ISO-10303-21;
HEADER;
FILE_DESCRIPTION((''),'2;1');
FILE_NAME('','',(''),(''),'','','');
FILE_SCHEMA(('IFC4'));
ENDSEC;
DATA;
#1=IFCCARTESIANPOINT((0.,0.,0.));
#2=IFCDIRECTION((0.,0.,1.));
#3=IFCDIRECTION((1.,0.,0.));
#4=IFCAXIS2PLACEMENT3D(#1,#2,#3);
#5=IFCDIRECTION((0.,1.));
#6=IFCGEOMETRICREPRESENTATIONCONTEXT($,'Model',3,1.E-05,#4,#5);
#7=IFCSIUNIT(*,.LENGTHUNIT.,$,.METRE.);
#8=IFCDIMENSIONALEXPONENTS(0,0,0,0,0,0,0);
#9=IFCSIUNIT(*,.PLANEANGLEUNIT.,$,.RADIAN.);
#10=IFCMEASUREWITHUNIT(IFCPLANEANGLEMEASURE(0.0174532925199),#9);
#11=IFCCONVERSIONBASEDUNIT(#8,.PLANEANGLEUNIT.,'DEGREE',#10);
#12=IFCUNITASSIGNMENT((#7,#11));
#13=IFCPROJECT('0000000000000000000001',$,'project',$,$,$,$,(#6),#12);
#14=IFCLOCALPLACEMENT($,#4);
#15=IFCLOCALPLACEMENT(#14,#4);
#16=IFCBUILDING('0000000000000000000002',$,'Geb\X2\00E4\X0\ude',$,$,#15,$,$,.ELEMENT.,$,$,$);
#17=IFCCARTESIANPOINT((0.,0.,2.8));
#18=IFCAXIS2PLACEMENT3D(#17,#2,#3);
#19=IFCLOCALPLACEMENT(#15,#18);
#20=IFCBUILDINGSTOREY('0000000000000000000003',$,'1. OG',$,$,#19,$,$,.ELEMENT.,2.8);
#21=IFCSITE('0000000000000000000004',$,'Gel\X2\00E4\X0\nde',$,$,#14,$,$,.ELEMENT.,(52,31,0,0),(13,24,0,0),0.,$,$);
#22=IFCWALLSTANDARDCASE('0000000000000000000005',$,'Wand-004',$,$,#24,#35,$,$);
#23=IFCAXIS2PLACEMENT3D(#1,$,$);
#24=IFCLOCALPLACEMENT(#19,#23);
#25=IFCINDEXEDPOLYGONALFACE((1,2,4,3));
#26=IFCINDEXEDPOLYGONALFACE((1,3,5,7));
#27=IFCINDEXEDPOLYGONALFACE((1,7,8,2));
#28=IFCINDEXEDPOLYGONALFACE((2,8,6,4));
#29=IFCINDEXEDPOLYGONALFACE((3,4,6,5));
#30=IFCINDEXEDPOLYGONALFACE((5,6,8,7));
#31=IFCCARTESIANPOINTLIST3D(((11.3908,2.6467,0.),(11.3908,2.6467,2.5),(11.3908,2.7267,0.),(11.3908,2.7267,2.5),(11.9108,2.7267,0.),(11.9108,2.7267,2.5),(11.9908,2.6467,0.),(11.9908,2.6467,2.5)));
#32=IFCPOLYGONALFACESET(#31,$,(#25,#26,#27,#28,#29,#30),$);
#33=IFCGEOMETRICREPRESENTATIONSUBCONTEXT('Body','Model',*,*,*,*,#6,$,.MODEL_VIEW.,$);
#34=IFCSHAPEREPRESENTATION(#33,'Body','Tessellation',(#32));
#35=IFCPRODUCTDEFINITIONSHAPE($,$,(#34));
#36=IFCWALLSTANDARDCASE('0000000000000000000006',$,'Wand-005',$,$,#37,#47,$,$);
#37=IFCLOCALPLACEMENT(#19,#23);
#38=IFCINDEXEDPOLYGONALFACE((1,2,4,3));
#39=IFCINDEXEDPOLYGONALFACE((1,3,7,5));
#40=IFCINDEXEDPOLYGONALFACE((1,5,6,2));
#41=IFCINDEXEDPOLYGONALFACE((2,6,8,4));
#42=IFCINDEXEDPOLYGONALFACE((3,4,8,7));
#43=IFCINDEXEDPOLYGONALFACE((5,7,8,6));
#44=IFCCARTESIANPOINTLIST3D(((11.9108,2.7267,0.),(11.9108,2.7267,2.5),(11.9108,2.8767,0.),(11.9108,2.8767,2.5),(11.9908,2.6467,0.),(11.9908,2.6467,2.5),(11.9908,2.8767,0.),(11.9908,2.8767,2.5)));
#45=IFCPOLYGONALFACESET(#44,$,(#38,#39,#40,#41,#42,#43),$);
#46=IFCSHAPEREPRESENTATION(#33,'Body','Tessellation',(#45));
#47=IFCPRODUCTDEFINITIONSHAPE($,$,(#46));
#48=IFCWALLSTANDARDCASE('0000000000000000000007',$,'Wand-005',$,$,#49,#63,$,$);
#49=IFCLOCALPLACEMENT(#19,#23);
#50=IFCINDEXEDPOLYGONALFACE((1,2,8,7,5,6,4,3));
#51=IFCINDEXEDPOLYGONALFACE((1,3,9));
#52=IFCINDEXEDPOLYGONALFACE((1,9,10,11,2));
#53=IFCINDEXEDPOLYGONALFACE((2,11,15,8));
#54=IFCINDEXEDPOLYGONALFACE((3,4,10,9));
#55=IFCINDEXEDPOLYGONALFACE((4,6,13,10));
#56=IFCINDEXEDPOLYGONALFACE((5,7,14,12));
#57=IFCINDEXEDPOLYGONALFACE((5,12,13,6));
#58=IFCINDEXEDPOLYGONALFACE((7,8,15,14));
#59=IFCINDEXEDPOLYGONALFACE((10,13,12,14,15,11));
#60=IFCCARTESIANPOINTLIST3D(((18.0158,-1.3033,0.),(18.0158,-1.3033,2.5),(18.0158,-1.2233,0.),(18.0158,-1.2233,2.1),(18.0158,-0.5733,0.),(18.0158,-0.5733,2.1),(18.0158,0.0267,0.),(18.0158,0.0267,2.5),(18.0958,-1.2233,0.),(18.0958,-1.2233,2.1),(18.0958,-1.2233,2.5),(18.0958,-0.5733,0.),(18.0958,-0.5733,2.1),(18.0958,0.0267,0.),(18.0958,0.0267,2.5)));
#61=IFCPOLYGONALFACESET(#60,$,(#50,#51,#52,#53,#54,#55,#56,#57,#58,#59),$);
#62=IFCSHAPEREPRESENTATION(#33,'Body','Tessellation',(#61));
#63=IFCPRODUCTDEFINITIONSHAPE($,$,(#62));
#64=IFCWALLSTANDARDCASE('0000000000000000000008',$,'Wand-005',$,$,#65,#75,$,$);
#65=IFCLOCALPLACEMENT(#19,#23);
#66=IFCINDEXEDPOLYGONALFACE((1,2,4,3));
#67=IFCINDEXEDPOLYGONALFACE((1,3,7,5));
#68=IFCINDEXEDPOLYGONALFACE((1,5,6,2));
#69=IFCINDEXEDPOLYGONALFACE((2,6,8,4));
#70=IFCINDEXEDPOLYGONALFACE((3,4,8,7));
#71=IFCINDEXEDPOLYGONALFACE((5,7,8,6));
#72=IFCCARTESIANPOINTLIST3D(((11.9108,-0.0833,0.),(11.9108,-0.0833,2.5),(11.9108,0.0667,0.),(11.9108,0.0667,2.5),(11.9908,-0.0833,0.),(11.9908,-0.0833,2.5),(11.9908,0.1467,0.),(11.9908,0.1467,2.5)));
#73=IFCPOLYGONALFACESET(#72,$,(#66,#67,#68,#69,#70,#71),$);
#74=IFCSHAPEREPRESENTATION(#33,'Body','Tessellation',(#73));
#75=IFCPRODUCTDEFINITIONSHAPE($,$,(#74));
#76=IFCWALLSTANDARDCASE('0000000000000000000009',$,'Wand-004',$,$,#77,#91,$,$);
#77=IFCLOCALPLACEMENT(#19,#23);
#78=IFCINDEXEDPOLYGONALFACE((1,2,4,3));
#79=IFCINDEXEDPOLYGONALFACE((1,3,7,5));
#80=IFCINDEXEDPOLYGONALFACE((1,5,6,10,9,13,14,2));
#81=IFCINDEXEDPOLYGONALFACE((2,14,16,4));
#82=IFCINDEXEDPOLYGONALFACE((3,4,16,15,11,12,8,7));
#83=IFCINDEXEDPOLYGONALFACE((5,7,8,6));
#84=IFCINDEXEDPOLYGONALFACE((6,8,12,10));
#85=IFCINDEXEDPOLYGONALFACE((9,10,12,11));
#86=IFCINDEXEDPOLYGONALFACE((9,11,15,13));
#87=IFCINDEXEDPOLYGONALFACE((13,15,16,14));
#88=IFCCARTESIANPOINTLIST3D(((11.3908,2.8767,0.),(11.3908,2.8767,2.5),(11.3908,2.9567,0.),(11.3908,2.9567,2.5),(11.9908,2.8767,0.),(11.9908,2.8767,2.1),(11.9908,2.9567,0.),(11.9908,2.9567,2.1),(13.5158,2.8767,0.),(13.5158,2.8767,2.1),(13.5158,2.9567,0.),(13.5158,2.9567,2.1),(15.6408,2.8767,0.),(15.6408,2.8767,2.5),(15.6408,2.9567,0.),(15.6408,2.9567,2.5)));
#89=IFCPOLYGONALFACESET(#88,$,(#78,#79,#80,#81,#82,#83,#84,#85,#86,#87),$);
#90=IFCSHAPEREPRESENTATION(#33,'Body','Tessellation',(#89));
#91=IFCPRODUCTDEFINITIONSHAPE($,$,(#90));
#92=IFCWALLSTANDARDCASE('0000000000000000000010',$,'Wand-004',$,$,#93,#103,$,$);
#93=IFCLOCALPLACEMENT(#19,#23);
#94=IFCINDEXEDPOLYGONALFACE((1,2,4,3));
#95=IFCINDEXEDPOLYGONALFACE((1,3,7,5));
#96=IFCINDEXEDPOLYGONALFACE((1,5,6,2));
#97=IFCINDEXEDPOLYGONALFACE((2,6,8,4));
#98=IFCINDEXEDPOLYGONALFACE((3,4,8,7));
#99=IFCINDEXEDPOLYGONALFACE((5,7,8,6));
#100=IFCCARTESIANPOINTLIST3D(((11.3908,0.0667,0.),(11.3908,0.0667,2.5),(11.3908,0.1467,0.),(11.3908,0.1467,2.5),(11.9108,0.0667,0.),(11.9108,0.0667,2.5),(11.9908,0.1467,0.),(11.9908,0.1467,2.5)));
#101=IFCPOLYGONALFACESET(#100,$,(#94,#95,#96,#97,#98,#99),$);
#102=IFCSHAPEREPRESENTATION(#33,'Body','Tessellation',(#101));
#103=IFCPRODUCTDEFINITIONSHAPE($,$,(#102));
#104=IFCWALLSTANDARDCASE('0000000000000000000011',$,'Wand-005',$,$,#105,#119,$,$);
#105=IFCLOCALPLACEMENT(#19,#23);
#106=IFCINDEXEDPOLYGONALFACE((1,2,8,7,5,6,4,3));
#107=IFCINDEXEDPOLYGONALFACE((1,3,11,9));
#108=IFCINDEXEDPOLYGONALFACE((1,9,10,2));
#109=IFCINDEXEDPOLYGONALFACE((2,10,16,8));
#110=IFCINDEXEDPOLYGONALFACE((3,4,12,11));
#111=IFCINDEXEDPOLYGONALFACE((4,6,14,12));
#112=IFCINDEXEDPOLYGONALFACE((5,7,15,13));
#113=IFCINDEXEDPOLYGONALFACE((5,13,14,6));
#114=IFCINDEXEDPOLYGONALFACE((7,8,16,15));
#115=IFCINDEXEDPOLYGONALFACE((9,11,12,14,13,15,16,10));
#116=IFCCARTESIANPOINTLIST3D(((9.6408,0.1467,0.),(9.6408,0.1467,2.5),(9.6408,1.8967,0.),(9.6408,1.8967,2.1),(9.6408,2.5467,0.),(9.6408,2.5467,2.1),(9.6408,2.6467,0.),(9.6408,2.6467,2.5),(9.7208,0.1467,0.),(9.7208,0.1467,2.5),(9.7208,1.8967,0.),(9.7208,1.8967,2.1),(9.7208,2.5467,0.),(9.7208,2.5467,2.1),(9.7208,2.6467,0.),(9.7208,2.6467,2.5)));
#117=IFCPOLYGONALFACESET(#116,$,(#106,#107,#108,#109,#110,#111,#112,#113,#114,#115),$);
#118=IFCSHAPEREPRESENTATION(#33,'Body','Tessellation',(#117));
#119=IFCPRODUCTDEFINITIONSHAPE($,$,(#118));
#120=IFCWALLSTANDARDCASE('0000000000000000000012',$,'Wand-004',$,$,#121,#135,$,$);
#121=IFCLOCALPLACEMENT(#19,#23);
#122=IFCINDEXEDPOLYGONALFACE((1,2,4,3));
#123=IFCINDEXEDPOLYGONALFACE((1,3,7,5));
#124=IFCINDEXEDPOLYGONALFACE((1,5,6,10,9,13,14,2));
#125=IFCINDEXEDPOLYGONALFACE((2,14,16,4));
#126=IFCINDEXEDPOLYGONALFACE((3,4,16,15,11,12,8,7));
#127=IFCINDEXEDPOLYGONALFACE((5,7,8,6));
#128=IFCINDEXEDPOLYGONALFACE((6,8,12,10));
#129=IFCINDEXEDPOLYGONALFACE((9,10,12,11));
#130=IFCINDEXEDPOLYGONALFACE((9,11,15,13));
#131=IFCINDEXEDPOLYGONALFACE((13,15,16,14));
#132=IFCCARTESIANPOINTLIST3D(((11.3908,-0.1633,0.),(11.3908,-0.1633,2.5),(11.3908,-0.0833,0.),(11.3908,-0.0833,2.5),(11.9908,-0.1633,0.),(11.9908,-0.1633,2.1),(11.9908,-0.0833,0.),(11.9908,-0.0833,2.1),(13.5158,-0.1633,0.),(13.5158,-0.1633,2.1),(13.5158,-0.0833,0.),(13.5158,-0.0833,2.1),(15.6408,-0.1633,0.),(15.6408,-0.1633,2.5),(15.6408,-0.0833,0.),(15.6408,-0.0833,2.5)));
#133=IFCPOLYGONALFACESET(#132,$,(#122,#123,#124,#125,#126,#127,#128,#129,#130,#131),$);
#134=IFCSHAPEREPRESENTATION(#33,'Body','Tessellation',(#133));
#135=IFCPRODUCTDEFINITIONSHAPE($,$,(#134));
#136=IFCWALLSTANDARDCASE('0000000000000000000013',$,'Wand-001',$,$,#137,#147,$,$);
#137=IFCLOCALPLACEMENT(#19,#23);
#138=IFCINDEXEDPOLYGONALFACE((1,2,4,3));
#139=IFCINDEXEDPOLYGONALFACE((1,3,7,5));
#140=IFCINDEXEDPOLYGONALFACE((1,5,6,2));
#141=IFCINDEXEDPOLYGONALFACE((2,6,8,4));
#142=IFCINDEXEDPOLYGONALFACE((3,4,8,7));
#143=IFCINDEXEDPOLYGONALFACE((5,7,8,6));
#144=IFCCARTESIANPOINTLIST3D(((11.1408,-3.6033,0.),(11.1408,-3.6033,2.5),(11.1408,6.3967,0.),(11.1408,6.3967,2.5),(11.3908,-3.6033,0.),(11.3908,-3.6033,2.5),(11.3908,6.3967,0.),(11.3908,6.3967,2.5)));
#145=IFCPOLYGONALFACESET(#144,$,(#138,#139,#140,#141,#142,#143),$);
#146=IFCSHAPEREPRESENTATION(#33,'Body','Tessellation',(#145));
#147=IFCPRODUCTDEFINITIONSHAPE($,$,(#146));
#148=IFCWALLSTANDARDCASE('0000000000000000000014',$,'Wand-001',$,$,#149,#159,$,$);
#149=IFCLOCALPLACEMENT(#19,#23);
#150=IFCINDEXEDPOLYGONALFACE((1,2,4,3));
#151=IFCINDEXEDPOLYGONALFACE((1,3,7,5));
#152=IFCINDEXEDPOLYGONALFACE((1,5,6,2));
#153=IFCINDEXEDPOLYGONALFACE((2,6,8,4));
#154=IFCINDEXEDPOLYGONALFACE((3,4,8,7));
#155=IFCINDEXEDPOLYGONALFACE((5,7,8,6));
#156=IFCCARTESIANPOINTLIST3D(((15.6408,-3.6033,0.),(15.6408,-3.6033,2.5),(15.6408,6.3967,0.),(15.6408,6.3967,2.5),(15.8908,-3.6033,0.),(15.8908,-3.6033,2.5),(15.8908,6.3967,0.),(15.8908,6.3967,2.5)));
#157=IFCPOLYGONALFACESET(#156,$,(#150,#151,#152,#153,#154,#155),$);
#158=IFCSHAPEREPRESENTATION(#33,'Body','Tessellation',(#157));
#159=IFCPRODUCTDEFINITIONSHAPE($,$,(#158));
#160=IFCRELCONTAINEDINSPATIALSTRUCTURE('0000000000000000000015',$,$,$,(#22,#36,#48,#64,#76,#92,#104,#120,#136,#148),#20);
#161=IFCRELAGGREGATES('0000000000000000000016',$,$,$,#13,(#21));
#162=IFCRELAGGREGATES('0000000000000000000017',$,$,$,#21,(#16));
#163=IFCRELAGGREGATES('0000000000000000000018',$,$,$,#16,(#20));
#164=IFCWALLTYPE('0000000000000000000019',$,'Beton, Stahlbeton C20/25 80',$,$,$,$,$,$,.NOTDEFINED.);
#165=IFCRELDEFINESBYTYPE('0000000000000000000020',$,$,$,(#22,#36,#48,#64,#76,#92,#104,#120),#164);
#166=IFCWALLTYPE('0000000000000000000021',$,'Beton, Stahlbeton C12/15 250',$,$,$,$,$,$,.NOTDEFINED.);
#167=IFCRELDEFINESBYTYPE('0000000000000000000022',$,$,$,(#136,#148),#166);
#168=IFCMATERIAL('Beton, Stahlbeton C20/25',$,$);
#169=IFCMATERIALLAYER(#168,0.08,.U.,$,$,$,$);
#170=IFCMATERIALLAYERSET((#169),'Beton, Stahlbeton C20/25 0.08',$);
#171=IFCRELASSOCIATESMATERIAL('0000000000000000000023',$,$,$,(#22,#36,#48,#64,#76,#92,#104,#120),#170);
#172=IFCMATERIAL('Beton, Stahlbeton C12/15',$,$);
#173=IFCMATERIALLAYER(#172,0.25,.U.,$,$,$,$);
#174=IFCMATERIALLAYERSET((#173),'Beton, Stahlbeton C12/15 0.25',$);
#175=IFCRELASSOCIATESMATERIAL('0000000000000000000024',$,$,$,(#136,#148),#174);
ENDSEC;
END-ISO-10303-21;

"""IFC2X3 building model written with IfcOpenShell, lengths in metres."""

from ifc_helpers import new_model, entity, si_unit, converted_unit, direction, frame, origin_with_axes, origin_2d_with_axis, place, context, subcontext, project, spatial, polyline, rectangle, outline, extrude, material, layer, layer_set, layer_usage, type_object, element, save


model = new_model("IFC2X3")

# Units and contexts
model_context = context("Model", 3, precision=1e-05, world=origin_with_axes(), true_north=direction((0.0, 1.0)))
body_context = subcontext(model_context, "Body", "Model", "MODEL_VIEW")
ifc_project = project(units=[si_unit("LENGTHUNIT", "METRE"), converted_unit("PLANEANGLEUNIT", "DEGREE", entity("IfcPlaneAngleMeasure", 0.0174532925199), si_unit("PLANEANGLEUNIT", "RADIAN"), dimensions=[0, 0, 0, 0, 0, 0, 0])], contexts=[model_context])

# Site, building, storey
site_placement = place(None, origin_with_axes())
site = spatial("IfcSite", under=ifc_project, at=site_placement, Name="Gelände", CompositionType="ELEMENT", RefLatitude=(52, 31, 0, 0), RefLongitude=(13, 24, 0, 0), RefElevation=0.0)
building_placement = place(site_placement, origin_with_axes())
building = spatial("IfcBuilding", under=site, at=building_placement, Name="Gebäude", CompositionType="ELEMENT")
storey_placement = place(building_placement, frame((0.0, 0.0, 2.8), z_axis=(0.0, 0.0, 1.0), x_axis=(1.0, 0.0, 0.0)))
storey = spatial("IfcBuildingStorey", under=building, at=storey_placement, Name="1. OG", CompositionType="ELEMENT", Elevation=2.8)

# Walls
ifc_material_1 = material(Name="Beton, Stahlbeton C20/25")
ifc_layer_1 = layer(ifc_material_1, 0.08, ventilated="UNKNOWN")
ifc_layer_set_1 = layer_set([ifc_layer_1], Name="Beton, Stahlbeton C20/25 0.08")
ifc_layer_usage_1 = layer_usage(ifc_layer_set_1, "AXIS2", "POSITIVE", 0.0)
wall_type_1 = type_object("IfcWallType", Name="Beton, Stahlbeton C20/25 80", PredefinedType="NOTDEFINED")
wall_1_placement = place(storey_placement, frame((11.9908, 2.7267, 0.0), z_axis=(0.0, 0.0, 1.0), x_axis=(-1.0, 0.0, 0.0)))
element("IfcWallStandardCase", 1, at=wall_1_placement, inside=storey, type_object=wall_type_1, material=ifc_layer_usage_1, Name="Wand-004", context=body_context, shape_type="SweptSolid", body=[
    extrude(outline(polyline([(0.08, 0.0), (0.6, 0.0), (0.6, 0.08), (0.0, 0.08), (0.08, 0.0)])), origin_with_axes(), (0.0, 0.0, 1.0), 2.5),
])
ifc_layer_usage_2 = layer_usage(ifc_layer_set_1, "AXIS2", "NEGATIVE", 0.0)
wall_2_placement = place(storey_placement, frame((11.9908, 2.9567, 0.0), z_axis=(0.0, 0.0, 1.0), x_axis=(0.0, -1.0, 0.0)))
element("IfcWallStandardCase", 2, at=wall_2_placement, inside=storey, type_object=wall_type_1, material=ifc_layer_usage_2, Name="Wand-005", context=body_context, shape_type="SweptSolid", body=[
    extrude(outline(polyline([(0.08, -0.08), (0.23, -0.08), (0.31, 0.0), (0.08, 0.0), (0.08, -0.08)])), origin_with_axes(), (0.0, 0.0, 1.0), 2.5),
])

# Wall, opening
ifc_layer_usage_3 = layer_usage(ifc_layer_set_1, "AXIS2", "NEGATIVE", 0.0)
wall_3_placement = place(storey_placement, frame((18.0158, -1.3033, 0.0), z_axis=(0.0, 0.0, 1.0), x_axis=(0.0, 1.0, 0.0)))
wall_3 = element("IfcWallStandardCase", 3, at=wall_3_placement, inside=storey, type_object=wall_type_1, material=ifc_layer_usage_3, Name="Wand-005", context=body_context, shape_type="SweptSolid", body=[
    extrude(outline(polyline([(0.08, -0.08), (1.33, -0.08), (1.33, 0.0), (0.0, 0.0), (0.08, -0.08)])), origin_with_axes(), (0.0, 0.0, 1.0), 2.5),
])
opening_1_placement = place(wall_3_placement, frame((0.405, 0.0, 0.0), z_axis=(0.0, 0.0, 1.0), x_axis=(1.0, 0.0, 0.0)))
element("IfcOpeningElement", 4, at=opening_1_placement, cuts=wall_3, context=body_context, shape_type="SweptSolid", body=[
    extrude(rectangle(XDim=0.65, YDim=2.1, at=origin_2d_with_axis()), frame((0.0, 0.08, 1.05), z_axis=(0.0, 1.0, 0.0), x_axis=(-1.0, 0.0, 0.0)), (0.0, 0.0, -1.0), 0.24),
])

# Wall
ifc_layer_usage_4 = layer_usage(ifc_layer_set_1, "AXIS2", "POSITIVE", 0.0)
wall_4_placement = place(storey_placement, frame((11.9908, -0.1633, 0.0), z_axis=(0.0, 0.0, 1.0), x_axis=(0.0, 1.0, 0.0)))
element("IfcWallStandardCase", 5, at=wall_4_placement, inside=storey, type_object=wall_type_1, material=ifc_layer_usage_4, Name="Wand-005", context=body_context, shape_type="SweptSolid", body=[
    extrude(outline(polyline([(0.08, 0.0), (0.31, 0.0), (0.23, 0.08), (0.08, 0.08), (0.08, 0.0)])), origin_with_axes(), (0.0, 0.0, 1.0), 2.5),
])

# Wall, opening
ifc_layer_usage_5 = layer_usage(ifc_layer_set_1, "AXIS2", "POSITIVE", 0.0)
wall_5_placement = place(storey_placement, frame((15.6408, 2.9567, 0.0), z_axis=(0.0, 0.0, 1.0), x_axis=(-1.0, 0.0, 0.0)))
wall_5 = element("IfcWallStandardCase", 6, at=wall_5_placement, inside=storey, type_object=wall_type_1, material=ifc_layer_usage_5, Name="Wand-004", context=body_context, shape_type="SweptSolid", body=[
    extrude(outline(polyline([(0.0, 0.0), (4.25, 0.0), (4.25, 0.08), (0.0, 0.08), (0.0, 0.0)])), origin_with_axes(), (0.0, 0.0, 1.0), 2.5),
])
opening_2_placement = place(wall_5_placement, frame((2.8875, 0.0, 0.0), z_axis=(0.0, 0.0, 1.0), x_axis=(1.0, 0.0, 0.0)))
element("IfcOpeningElement", 7, at=opening_2_placement, cuts=wall_5, context=body_context, shape_type="SweptSolid", body=[
    extrude(rectangle(XDim=1.525, YDim=2.1, at=origin_2d_with_axis()), frame((0.0, 0.16, 1.05), z_axis=(0.0, -1.0, 0.0), x_axis=(1.0, 0.0, 0.0)), (0.0, 0.0, 1.0), 0.08),
    extrude(rectangle(XDim=1.525, YDim=2.1, at=origin_2d_with_axis()), frame((0.0, 0.0, 1.05), z_axis=(0.0, 1.0, 0.0), x_axis=(1.0, 0.0, 0.0)), (0.0, 0.0, 1.0), 0.08),
])

# Wall
ifc_layer_usage_6 = layer_usage(ifc_layer_set_1, "AXIS2", "NEGATIVE", 0.0)
wall_6_placement = place(storey_placement, frame((11.9908, 0.0667, 0.0), z_axis=(0.0, 0.0, 1.0), x_axis=(-1.0, 0.0, 0.0)))
element("IfcWallStandardCase", 8, at=wall_6_placement, inside=storey, type_object=wall_type_1, material=ifc_layer_usage_6, Name="Wand-004", context=body_context, shape_type="SweptSolid", body=[
    extrude(outline(polyline([(0.0, -0.08), (0.6, -0.08), (0.6, 0.0), (0.08, 0.0), (0.0, -0.08)])), origin_with_axes(), (0.0, 0.0, 1.0), 2.5),
])

# Walls, openings
ifc_layer_usage_7 = layer_usage(ifc_layer_set_1, "AXIS2", "NEGATIVE", 0.0)
wall_7_placement = place(storey_placement, frame((9.6408, 0.1467, 0.0), z_axis=(0.0, 0.0, 1.0), x_axis=(0.0, 1.0, 0.0)))
wall_7 = element("IfcWallStandardCase", 9, at=wall_7_placement, inside=storey, type_object=wall_type_1, material=ifc_layer_usage_7, Name="Wand-005", context=body_context, shape_type="SweptSolid", body=[
    extrude(outline(polyline([(0.0, -0.08), (2.5, -0.08), (2.5, 0.0), (0.0, 0.0), (0.0, -0.08)])), origin_with_axes(), (0.0, 0.0, 1.0), 2.5),
])
opening_3_placement = place(wall_7_placement, frame((2.075, 0.0, 0.0), z_axis=(0.0, 0.0, 1.0), x_axis=(1.0, 0.0, 0.0)))
element("IfcOpeningElement", 10, at=opening_3_placement, cuts=wall_7, context=body_context, shape_type="SweptSolid", body=[
    extrude(rectangle(XDim=0.65, YDim=2.1, at=origin_2d_with_axis()), frame((0.0, 0.08, 1.05), z_axis=(0.0, 1.0, 0.0), x_axis=(-1.0, 0.0, 0.0)), (0.0, 0.0, -1.0), 0.24),
])
ifc_layer_usage_8 = layer_usage(ifc_layer_set_1, "AXIS2", "NEGATIVE", 0.0)
wall_8_placement = place(storey_placement, frame((15.6408, -0.1633, 0.0), z_axis=(0.0, 0.0, 1.0), x_axis=(-1.0, 0.0, 0.0)))
wall_8 = element("IfcWallStandardCase", 11, at=wall_8_placement, inside=storey, type_object=wall_type_1, material=ifc_layer_usage_8, Name="Wand-004", context=body_context, shape_type="SweptSolid", body=[
    extrude(outline(polyline([(0.0, -0.08), (4.25, -0.08), (4.25, 0.0), (0.0, 0.0), (0.0, -0.08)])), origin_with_axes(), (0.0, 0.0, 1.0), 2.5),
])
opening_4_placement = place(wall_8_placement, frame((2.8875, 0.0, 0.0), z_axis=(0.0, 0.0, 1.0), x_axis=(1.0, 0.0, 0.0)))
element("IfcOpeningElement", 12, at=opening_4_placement, cuts=wall_8, context=body_context, shape_type="SweptSolid", body=[
    extrude(rectangle(XDim=1.525, YDim=2.1, at=origin_2d_with_axis()), frame((0.0, -0.16, 1.05), z_axis=(0.0, 1.0, 0.0), x_axis=(1.0, 0.0, 0.0)), (0.0, 0.0, 1.0), 0.08),
    extrude(rectangle(XDim=1.525, YDim=2.1, at=origin_2d_with_axis()), frame((0.0, 0.0, 1.05), z_axis=(0.0, -1.0, 0.0), x_axis=(1.0, 0.0, 0.0)), (0.0, 0.0, 1.0), 0.08),
])

# Walls
ifc_material_2 = material(Name="Beton, Stahlbeton C12/15")
ifc_layer_2 = layer(ifc_material_2, 0.25, ventilated="UNKNOWN")
ifc_layer_set_2 = layer_set([ifc_layer_2], Name="Beton, Stahlbeton C12/15 0.25")
ifc_layer_usage_9 = layer_usage(ifc_layer_set_2, "AXIS2", "POSITIVE", 0.0)
wall_type_2 = type_object("IfcWallType", Name="Beton, Stahlbeton C12/15 250", PredefinedType="NOTDEFINED")
wall_9_placement = place(storey_placement, frame((11.3908, -3.6033, 0.0), z_axis=(0.0, 0.0, 1.0), x_axis=(0.0, 1.0, 0.0)))
element("IfcWallStandardCase", 13, at=wall_9_placement, inside=storey, type_object=wall_type_2, material=ifc_layer_usage_9, Name="Wand-001", context=body_context, shape_type="SweptSolid", body=[
    extrude(outline(polyline([(0.0, 0.0), (10.0, 0.0), (10.0, 0.25), (0.0, 0.25), (0.0, 0.0)])), origin_with_axes(), (0.0, 0.0, 1.0), 2.5),
])
ifc_layer_usage_10 = layer_usage(ifc_layer_set_2, "AXIS2", "POSITIVE", 0.0)
wall_10_placement = place(storey_placement, frame((15.8908, -3.6033, 0.0), z_axis=(0.0, 0.0, 1.0), x_axis=(0.0, 1.0, 0.0)))
element("IfcWallStandardCase", 14, at=wall_10_placement, inside=storey, type_object=wall_type_2, material=ifc_layer_usage_10, Name="Wand-001", context=body_context, shape_type="SweptSolid", body=[
    extrude(outline(polyline([(0.0, 0.0), (10.0, 0.0), (10.0, 0.25), (0.0, 0.25), (0.0, 0.0)])), origin_with_axes(), (0.0, 0.0, 1.0), 2.5),
])

save(model, "model.ifc")
